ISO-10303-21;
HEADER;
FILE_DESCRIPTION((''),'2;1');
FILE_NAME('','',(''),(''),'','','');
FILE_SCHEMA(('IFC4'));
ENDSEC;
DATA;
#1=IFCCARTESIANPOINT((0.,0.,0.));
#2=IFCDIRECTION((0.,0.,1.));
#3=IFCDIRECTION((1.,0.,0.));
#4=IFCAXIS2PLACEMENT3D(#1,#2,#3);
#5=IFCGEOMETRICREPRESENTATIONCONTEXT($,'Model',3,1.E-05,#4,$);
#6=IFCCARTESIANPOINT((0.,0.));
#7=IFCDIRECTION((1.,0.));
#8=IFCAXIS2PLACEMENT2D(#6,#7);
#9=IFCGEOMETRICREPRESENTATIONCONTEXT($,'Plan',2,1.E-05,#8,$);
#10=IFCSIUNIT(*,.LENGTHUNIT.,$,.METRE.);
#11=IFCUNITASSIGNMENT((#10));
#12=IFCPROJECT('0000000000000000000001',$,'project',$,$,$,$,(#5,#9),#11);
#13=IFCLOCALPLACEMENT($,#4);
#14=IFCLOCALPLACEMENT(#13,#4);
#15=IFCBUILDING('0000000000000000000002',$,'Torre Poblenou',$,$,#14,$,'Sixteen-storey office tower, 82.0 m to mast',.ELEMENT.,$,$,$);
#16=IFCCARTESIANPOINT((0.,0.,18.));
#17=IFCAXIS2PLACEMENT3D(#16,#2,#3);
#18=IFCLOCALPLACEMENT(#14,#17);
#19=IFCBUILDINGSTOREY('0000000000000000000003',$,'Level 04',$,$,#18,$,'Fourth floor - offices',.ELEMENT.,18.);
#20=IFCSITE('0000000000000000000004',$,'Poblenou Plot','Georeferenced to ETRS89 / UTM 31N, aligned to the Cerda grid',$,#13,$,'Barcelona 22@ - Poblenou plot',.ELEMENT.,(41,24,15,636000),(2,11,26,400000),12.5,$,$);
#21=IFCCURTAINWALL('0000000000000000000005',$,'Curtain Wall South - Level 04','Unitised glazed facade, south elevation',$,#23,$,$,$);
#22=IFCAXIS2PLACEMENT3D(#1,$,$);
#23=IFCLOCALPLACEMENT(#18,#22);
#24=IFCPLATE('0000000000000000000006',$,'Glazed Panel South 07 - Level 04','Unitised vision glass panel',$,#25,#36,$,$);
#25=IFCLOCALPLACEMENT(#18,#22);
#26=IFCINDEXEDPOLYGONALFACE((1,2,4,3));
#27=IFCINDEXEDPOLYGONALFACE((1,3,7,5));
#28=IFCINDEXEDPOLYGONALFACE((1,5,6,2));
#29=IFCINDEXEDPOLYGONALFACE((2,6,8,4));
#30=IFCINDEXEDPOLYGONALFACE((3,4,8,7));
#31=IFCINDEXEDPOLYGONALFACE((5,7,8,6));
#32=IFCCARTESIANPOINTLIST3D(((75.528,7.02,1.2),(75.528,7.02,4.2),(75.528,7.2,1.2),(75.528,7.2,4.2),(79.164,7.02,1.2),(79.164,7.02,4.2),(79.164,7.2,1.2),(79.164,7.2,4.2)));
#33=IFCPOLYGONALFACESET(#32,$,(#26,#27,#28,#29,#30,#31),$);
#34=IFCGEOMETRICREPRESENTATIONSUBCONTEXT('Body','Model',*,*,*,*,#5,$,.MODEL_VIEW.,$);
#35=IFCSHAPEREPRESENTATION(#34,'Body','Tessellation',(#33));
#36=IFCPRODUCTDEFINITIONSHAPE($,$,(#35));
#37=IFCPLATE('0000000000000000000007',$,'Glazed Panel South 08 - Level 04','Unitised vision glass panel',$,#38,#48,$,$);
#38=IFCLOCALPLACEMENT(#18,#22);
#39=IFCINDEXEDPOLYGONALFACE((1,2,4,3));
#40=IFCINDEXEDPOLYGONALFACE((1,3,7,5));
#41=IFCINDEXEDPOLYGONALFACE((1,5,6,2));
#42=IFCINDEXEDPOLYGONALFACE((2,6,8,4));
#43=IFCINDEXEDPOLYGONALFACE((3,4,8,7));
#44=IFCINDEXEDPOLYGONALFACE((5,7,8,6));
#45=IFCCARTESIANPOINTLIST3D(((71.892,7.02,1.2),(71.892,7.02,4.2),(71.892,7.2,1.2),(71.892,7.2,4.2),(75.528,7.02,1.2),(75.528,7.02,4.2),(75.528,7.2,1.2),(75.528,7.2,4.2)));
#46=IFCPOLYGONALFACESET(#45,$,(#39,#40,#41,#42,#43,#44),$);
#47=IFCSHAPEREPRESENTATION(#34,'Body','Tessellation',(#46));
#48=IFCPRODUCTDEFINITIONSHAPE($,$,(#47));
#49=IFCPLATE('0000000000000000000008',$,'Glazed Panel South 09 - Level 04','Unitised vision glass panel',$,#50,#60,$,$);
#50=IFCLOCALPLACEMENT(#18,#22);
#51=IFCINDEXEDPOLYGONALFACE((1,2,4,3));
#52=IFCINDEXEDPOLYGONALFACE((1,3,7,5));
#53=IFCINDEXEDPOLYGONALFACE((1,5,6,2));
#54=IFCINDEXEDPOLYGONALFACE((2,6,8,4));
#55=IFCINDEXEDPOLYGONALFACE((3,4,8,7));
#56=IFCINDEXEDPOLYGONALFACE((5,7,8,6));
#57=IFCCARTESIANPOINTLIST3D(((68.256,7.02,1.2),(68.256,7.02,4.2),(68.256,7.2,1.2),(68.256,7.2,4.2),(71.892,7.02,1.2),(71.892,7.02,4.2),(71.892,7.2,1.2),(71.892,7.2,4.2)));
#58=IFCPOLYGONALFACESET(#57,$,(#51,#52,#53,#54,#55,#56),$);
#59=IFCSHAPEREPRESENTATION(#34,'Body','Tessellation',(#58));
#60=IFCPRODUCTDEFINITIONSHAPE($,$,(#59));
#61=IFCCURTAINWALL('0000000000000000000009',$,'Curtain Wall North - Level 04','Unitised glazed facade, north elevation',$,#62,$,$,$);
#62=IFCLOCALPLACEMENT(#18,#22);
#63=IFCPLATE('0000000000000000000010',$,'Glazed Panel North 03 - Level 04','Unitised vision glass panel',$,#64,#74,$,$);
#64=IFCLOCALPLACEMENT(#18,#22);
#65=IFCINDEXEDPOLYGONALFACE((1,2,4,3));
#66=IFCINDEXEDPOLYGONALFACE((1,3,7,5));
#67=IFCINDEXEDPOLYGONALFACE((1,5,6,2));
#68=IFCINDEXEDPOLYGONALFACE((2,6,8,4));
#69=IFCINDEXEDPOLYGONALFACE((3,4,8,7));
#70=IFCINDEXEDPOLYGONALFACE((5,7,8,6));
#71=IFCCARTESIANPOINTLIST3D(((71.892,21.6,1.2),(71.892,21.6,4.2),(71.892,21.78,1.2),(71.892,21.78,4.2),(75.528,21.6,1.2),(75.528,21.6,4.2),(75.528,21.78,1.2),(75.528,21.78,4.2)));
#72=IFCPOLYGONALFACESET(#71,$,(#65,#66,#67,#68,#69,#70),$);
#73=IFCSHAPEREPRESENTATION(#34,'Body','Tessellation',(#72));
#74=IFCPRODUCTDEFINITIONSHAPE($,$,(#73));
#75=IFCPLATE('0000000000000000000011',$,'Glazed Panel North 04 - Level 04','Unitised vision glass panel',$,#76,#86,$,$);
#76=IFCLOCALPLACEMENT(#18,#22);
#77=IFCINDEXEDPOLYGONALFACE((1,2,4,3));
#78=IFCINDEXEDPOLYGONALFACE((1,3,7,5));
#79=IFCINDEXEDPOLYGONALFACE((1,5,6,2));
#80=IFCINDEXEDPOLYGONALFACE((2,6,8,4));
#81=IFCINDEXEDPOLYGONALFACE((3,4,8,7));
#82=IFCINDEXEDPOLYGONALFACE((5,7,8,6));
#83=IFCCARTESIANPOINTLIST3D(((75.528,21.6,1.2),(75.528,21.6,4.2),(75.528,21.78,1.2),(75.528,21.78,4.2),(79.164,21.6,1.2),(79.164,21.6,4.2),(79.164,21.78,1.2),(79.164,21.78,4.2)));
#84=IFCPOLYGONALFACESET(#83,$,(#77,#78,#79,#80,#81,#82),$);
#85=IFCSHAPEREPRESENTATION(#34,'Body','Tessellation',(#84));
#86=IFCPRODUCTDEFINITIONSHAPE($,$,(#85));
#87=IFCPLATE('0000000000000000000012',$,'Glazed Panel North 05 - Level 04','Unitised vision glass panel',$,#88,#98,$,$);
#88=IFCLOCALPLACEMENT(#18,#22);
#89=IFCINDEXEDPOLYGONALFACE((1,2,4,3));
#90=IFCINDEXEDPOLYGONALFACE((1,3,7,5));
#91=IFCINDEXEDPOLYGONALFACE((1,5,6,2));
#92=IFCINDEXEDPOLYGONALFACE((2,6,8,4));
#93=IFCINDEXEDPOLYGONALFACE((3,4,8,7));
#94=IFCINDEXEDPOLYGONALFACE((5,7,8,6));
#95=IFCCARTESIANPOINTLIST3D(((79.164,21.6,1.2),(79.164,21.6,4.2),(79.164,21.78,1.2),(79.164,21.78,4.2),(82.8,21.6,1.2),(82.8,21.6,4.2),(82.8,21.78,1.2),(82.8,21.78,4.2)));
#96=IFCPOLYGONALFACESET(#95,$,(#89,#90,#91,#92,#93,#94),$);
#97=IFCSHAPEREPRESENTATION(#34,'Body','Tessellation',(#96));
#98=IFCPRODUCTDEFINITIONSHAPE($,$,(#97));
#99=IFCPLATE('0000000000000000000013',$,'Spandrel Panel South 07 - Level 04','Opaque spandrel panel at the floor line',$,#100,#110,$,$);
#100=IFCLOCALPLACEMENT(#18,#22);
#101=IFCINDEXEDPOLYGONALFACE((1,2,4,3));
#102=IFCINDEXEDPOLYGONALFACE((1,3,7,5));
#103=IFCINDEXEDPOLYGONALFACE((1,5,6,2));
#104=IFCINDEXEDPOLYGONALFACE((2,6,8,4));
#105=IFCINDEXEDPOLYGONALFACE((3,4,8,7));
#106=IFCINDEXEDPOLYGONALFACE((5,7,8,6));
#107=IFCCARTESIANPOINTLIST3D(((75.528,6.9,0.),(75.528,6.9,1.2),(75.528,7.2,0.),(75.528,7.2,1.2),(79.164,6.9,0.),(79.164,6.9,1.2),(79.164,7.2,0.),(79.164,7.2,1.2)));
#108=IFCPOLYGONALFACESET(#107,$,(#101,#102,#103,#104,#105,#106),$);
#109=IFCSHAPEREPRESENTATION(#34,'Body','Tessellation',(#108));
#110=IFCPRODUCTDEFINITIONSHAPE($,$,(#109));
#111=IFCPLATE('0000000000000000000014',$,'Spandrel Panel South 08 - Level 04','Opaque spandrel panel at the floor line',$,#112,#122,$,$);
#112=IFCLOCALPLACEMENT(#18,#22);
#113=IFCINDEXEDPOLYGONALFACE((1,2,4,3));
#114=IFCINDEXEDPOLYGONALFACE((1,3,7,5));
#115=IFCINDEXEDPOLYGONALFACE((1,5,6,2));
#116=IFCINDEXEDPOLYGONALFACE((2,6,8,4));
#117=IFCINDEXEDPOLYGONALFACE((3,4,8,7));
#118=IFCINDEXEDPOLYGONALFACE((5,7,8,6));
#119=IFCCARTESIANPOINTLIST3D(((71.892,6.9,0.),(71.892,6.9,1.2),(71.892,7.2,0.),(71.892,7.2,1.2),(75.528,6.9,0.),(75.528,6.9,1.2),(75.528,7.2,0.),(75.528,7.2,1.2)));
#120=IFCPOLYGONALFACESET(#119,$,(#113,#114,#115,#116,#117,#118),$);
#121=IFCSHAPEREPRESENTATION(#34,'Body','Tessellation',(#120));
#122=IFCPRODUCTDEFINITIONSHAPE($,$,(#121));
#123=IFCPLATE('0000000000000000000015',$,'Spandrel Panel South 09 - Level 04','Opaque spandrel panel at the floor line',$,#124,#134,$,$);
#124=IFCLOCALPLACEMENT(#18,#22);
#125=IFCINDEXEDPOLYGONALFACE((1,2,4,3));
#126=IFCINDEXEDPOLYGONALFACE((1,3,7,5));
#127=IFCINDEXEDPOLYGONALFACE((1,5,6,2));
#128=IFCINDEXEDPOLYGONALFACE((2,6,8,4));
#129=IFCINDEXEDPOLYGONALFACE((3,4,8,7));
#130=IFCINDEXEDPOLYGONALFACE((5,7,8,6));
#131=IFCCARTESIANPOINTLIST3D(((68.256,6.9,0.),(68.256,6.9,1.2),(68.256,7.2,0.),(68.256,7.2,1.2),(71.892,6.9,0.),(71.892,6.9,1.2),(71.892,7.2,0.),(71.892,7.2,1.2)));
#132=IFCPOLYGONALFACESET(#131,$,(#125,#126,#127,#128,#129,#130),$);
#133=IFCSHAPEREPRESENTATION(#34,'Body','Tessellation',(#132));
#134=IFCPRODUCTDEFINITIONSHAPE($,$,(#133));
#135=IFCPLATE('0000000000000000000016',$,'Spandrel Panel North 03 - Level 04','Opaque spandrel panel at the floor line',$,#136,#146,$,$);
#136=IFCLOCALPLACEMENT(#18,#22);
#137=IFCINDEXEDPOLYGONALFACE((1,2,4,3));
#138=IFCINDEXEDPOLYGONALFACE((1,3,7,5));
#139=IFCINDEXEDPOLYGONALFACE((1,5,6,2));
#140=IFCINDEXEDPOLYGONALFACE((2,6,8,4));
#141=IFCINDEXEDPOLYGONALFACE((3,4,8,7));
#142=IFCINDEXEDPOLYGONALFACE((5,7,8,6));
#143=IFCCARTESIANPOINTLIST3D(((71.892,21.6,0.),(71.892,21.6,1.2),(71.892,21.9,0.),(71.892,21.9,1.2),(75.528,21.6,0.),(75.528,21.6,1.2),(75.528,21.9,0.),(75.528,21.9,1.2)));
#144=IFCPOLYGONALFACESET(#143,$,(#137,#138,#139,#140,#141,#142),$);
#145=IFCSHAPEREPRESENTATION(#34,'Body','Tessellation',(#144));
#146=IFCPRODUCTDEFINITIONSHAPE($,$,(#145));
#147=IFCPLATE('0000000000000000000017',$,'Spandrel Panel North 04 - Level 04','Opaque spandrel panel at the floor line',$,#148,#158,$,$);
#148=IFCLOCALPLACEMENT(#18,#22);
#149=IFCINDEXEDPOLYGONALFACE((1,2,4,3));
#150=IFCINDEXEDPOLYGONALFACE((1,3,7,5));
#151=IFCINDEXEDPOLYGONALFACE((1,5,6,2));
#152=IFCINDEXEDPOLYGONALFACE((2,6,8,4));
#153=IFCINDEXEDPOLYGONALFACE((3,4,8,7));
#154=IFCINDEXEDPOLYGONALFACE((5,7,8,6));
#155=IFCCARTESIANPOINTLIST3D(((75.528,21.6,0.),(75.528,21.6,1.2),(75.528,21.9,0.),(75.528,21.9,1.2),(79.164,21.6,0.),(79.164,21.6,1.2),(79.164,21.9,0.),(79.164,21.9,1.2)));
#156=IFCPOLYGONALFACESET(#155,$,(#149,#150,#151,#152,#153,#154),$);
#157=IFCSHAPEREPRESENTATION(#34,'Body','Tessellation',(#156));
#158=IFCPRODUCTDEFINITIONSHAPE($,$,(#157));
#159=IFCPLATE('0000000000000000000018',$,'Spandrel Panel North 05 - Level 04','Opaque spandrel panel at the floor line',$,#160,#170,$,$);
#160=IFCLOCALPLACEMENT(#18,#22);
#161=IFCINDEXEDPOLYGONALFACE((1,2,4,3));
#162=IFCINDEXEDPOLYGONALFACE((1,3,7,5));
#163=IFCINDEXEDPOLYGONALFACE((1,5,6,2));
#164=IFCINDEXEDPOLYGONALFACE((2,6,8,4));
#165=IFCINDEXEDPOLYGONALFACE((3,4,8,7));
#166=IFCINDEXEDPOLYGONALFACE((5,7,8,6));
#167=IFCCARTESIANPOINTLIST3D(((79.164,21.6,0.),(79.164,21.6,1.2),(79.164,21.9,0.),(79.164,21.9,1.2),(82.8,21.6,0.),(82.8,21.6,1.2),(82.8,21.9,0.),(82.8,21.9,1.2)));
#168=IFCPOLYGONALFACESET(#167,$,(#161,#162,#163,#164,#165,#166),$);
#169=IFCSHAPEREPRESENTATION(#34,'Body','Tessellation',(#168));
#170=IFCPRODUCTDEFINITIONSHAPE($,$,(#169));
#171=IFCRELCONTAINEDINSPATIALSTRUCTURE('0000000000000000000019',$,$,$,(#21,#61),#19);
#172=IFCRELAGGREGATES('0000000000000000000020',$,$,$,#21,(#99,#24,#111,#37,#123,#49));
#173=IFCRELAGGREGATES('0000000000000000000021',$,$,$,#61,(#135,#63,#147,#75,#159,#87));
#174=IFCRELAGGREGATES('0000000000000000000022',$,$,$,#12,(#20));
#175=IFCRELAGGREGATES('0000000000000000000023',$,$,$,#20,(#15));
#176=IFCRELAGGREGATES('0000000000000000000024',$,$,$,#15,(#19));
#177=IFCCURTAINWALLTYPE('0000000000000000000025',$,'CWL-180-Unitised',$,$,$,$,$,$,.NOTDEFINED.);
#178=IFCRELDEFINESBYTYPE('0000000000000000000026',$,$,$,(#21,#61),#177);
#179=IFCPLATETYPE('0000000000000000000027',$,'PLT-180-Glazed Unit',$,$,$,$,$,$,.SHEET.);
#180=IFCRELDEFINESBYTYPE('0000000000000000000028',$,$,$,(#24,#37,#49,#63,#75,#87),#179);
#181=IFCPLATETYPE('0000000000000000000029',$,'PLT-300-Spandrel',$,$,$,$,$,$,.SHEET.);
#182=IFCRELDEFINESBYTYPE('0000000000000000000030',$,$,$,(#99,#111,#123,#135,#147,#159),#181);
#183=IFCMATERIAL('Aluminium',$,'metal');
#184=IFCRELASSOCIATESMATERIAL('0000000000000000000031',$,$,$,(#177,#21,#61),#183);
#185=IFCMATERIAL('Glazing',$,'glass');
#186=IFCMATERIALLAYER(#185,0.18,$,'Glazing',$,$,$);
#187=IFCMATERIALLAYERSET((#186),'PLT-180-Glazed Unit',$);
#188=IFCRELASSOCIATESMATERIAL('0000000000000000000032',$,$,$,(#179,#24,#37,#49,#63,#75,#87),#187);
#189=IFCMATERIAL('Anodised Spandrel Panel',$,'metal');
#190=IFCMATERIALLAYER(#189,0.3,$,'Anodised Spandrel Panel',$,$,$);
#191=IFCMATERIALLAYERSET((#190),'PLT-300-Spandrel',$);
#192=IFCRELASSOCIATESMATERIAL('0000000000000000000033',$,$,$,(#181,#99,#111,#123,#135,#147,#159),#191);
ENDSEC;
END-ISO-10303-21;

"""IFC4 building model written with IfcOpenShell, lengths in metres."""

from ifc_helpers import new_model, si_unit, frame, origin_with_axes, origin_2d_with_axis, place, context, subcontext, project, spatial, line, indexed_curve, outline, extrude, material, layer, layer_set, layer_usage, type_object, element, aggregate, save


model = new_model("IFC4")

# Units and contexts
model_context = context("Model", 3, precision=1e-05, world=origin_with_axes())
plan_context = context("Plan", 2, precision=1e-05, world=origin_2d_with_axis())
body_context = subcontext(model_context, "Body", "Model", "MODEL_VIEW")
ifc_project = project(units=[si_unit("LENGTHUNIT", "METRE")], contexts=[model_context, plan_context])

# Site, building, storey
site_placement = place(None, origin_with_axes())
site = spatial("IfcSite", under=ifc_project, at=site_placement, Name="Poblenou Plot", Description="Georeferenced to ETRS89 / UTM 31N, aligned to the Cerda grid", LongName="Barcelona 22@ - Poblenou plot", CompositionType="ELEMENT", RefLatitude=(41, 24, 15, 636000), RefLongitude=(2, 11, 26, 400000), RefElevation=12.5)
building_placement = place(site_placement, origin_with_axes())
building = spatial("IfcBuilding", under=site, at=building_placement, Name="Torre Poblenou", LongName="Sixteen-storey office tower, 82.0 m to mast", CompositionType="ELEMENT")
storey_placement = place(building_placement, frame((0.0, 0.0, 18.0), z_axis=(0.0, 0.0, 1.0), x_axis=(1.0, 0.0, 0.0)))
storey = spatial("IfcBuildingStorey", under=building, at=storey_placement, Name="Level 04", LongName="Fourth floor - offices", CompositionType="ELEMENT", Elevation=18.0)

# Curtain walls, plates
ifc_material_1 = material(Name="Aluminium", Category="metal")
curtain_wall_type = type_object("IfcCurtainWallType", Name="CWL-180-Unitised", PredefinedType="NOTDEFINED", material=ifc_material_1)
curtain_wall_1_placement = place(storey_placement, frame((100.98, 7.2, 0.0), z_axis=(0.0, 0.0, 1.0), x_axis=(-1.0, 0.0, 0.0)))
curtain_wall_1 = element("IfcCurtainWall", 1, at=curtain_wall_1_placement, inside=storey, type_object=curtain_wall_type, material=ifc_material_1, Name="Curtain Wall South - Level 04", Description="Unitised glazed facade, south elevation")
ifc_material_2 = material(Name="Glazing", Category="glass")
ifc_layer_1 = layer(ifc_material_2, 0.18, Name="Glazing")
ifc_layer_set_1 = layer_set([ifc_layer_1], Name="PLT-180-Glazed Unit")
ifc_layer_usage_1 = layer_usage(ifc_layer_set_1, "AXIS2", "POSITIVE", 0.0)
plate_type_1 = type_object("IfcPlateType", Name="PLT-180-Glazed Unit", PredefinedType="SHEET", material=ifc_layer_set_1)
plate_1_placement = place(curtain_wall_1_placement, frame((21.816, 0.0, 1.2), z_axis=(0.0, 0.0, 1.0), x_axis=(1.0, 0.0, 0.0)))
plate_1 = element("IfcPlate", 2, at=plate_1_placement, type_object=plate_type_1, material=ifc_layer_usage_1, Name="Glazed Panel South 07 - Level 04", Description="Unitised vision glass panel", context=body_context, shape_type="SweptSolid", body=[
    extrude(outline(indexed_curve([(0.0, 0.0), (3.636, 0.0), (3.636, 0.18), (0.0, 0.18)], segments=[line(1, 2, 3, 4, 1)])), origin_with_axes(), (0.0, 0.0, 1.0), 3.0),
])
ifc_layer_usage_2 = layer_usage(ifc_layer_set_1, "AXIS2", "POSITIVE", 0.0)
plate_2_placement = place(curtain_wall_1_placement, frame((25.452, 0.0, 1.2), z_axis=(0.0, 0.0, 1.0), x_axis=(1.0, 0.0, 0.0)))
plate_2 = element("IfcPlate", 3, at=plate_2_placement, type_object=plate_type_1, material=ifc_layer_usage_2, Name="Glazed Panel South 08 - Level 04", Description="Unitised vision glass panel", context=body_context, shape_type="SweptSolid", body=[
    extrude(outline(indexed_curve([(0.0, 0.0), (3.636, 0.0), (3.636, 0.18), (0.0, 0.18)], segments=[line(1, 2, 3, 4, 1)])), origin_with_axes(), (0.0, 0.0, 1.0), 3.0),
])
ifc_layer_usage_3 = layer_usage(ifc_layer_set_1, "AXIS2", "POSITIVE", 0.0)
plate_3_placement = place(curtain_wall_1_placement, frame((29.088, 0.0, 1.2), z_axis=(0.0, 0.0, 1.0), x_axis=(1.0, 0.0, 0.0)))
plate_3 = element("IfcPlate", 4, at=plate_3_placement, type_object=plate_type_1, material=ifc_layer_usage_3, Name="Glazed Panel South 09 - Level 04", Description="Unitised vision glass panel", context=body_context, shape_type="SweptSolid", body=[
    extrude(outline(indexed_curve([(0.0, 0.0), (3.636, 0.0), (3.636, 0.18), (0.0, 0.18)], segments=[line(1, 2, 3, 4, 1)])), origin_with_axes(), (0.0, 0.0, 1.0), 3.0),
])
curtain_wall_2_placement = place(storey_placement, frame((64.62, 21.6, 0.0), z_axis=(0.0, 0.0, 1.0), x_axis=(1.0, 0.0, 0.0)))
curtain_wall_2 = element("IfcCurtainWall", 5, at=curtain_wall_2_placement, inside=storey, type_object=curtain_wall_type, material=ifc_material_1, Name="Curtain Wall North - Level 04", Description="Unitised glazed facade, north elevation")
ifc_layer_usage_4 = layer_usage(ifc_layer_set_1, "AXIS2", "POSITIVE", 0.0)
plate_4_placement = place(curtain_wall_2_placement, frame((7.272, 0.0, 1.2), z_axis=(0.0, 0.0, 1.0), x_axis=(1.0, 0.0, 0.0)))
plate_4 = element("IfcPlate", 6, at=plate_4_placement, type_object=plate_type_1, material=ifc_layer_usage_4, Name="Glazed Panel North 03 - Level 04", Description="Unitised vision glass panel", context=body_context, shape_type="SweptSolid", body=[
    extrude(outline(indexed_curve([(0.0, 0.0), (3.636, 0.0), (3.636, 0.18), (0.0, 0.18)], segments=[line(1, 2, 3, 4, 1)])), origin_with_axes(), (0.0, 0.0, 1.0), 3.0),
])
ifc_layer_usage_5 = layer_usage(ifc_layer_set_1, "AXIS2", "POSITIVE", 0.0)
plate_5_placement = place(curtain_wall_2_placement, frame((10.908, 0.0, 1.2), z_axis=(0.0, 0.0, 1.0), x_axis=(1.0, 0.0, 0.0)))
plate_5 = element("IfcPlate", 7, at=plate_5_placement, type_object=plate_type_1, material=ifc_layer_usage_5, Name="Glazed Panel North 04 - Level 04", Description="Unitised vision glass panel", context=body_context, shape_type="SweptSolid", body=[
    extrude(outline(indexed_curve([(0.0, 0.0), (3.636, 0.0), (3.636, 0.18), (0.0, 0.18)], segments=[line(1, 2, 3, 4, 1)])), origin_with_axes(), (0.0, 0.0, 1.0), 3.0),
])
ifc_layer_usage_6 = layer_usage(ifc_layer_set_1, "AXIS2", "POSITIVE", 0.0)
plate_6_placement = place(curtain_wall_2_placement, frame((14.544, 0.0, 1.2), z_axis=(0.0, 0.0, 1.0), x_axis=(1.0, 0.0, 0.0)))
plate_6 = element("IfcPlate", 8, at=plate_6_placement, type_object=plate_type_1, material=ifc_layer_usage_6, Name="Glazed Panel North 05 - Level 04", Description="Unitised vision glass panel", context=body_context, shape_type="SweptSolid", body=[
    extrude(outline(indexed_curve([(0.0, 0.0), (3.636, 0.0), (3.636, 0.18), (0.0, 0.18)], segments=[line(1, 2, 3, 4, 1)])), origin_with_axes(), (0.0, 0.0, 1.0), 3.0),
])

# Plates
ifc_material_3 = material(Name="Anodised Spandrel Panel", Category="metal")
ifc_layer_2 = layer(ifc_material_3, 0.3, Name="Anodised Spandrel Panel")
ifc_layer_set_2 = layer_set([ifc_layer_2], Name="PLT-300-Spandrel")
ifc_layer_usage_7 = layer_usage(ifc_layer_set_2, "AXIS2", "POSITIVE", 0.0)
plate_type_2 = type_object("IfcPlateType", Name="PLT-300-Spandrel", PredefinedType="SHEET", material=ifc_layer_set_2)
plate_7_placement = place(curtain_wall_1_placement, frame((21.816, 0.0, 0.0), z_axis=(0.0, 0.0, 1.0), x_axis=(1.0, 0.0, 0.0)))
plate_7 = element("IfcPlate", 9, at=plate_7_placement, type_object=plate_type_2, material=ifc_layer_usage_7, Name="Spandrel Panel South 07 - Level 04", Description="Opaque spandrel panel at the floor line", context=body_context, shape_type="SweptSolid", body=[
    extrude(outline(indexed_curve([(0.0, 0.0), (3.636, 0.0), (3.636, 0.3), (0.0, 0.3)], segments=[line(1, 2, 3, 4, 1)])), origin_with_axes(), (0.0, 0.0, 1.0), 1.2),
])
ifc_layer_usage_8 = layer_usage(ifc_layer_set_2, "AXIS2", "POSITIVE", 0.0)
plate_8_placement = place(curtain_wall_1_placement, frame((25.452, 0.0, 0.0), z_axis=(0.0, 0.0, 1.0), x_axis=(1.0, 0.0, 0.0)))
plate_8 = element("IfcPlate", 10, at=plate_8_placement, type_object=plate_type_2, material=ifc_layer_usage_8, Name="Spandrel Panel South 08 - Level 04", Description="Opaque spandrel panel at the floor line", context=body_context, shape_type="SweptSolid", body=[
    extrude(outline(indexed_curve([(0.0, 0.0), (3.636, 0.0), (3.636, 0.3), (0.0, 0.3)], segments=[line(1, 2, 3, 4, 1)])), origin_with_axes(), (0.0, 0.0, 1.0), 1.2),
])
ifc_layer_usage_9 = layer_usage(ifc_layer_set_2, "AXIS2", "POSITIVE", 0.0)
plate_9_placement = place(curtain_wall_1_placement, frame((29.088, 0.0, 0.0), z_axis=(0.0, 0.0, 1.0), x_axis=(1.0, 0.0, 0.0)))
plate_9 = element("IfcPlate", 11, at=plate_9_placement, type_object=plate_type_2, material=ifc_layer_usage_9, Name="Spandrel Panel South 09 - Level 04", Description="Opaque spandrel panel at the floor line", context=body_context, shape_type="SweptSolid", body=[
    extrude(outline(indexed_curve([(0.0, 0.0), (3.636, 0.0), (3.636, 0.3), (0.0, 0.3)], segments=[line(1, 2, 3, 4, 1)])), origin_with_axes(), (0.0, 0.0, 1.0), 1.2),
])
aggregate(curtain_wall_1, [plate_7, plate_1, plate_8, plate_2, plate_9, plate_3])
ifc_layer_usage_10 = layer_usage(ifc_layer_set_2, "AXIS2", "POSITIVE", 0.0)
plate_10_placement = place(curtain_wall_2_placement, frame((7.272, 0.0, 0.0), z_axis=(0.0, 0.0, 1.0), x_axis=(1.0, 0.0, 0.0)))
plate_10 = element("IfcPlate", 12, at=plate_10_placement, type_object=plate_type_2, material=ifc_layer_usage_10, Name="Spandrel Panel North 03 - Level 04", Description="Opaque spandrel panel at the floor line", context=body_context, shape_type="SweptSolid", body=[
    extrude(outline(indexed_curve([(0.0, 0.0), (3.636, 0.0), (3.636, 0.3), (0.0, 0.3)], segments=[line(1, 2, 3, 4, 1)])), origin_with_axes(), (0.0, 0.0, 1.0), 1.2),
])
ifc_layer_usage_11 = layer_usage(ifc_layer_set_2, "AXIS2", "POSITIVE", 0.0)
plate_11_placement = place(curtain_wall_2_placement, frame((10.908, 0.0, 0.0), z_axis=(0.0, 0.0, 1.0), x_axis=(1.0, 0.0, 0.0)))
plate_11 = element("IfcPlate", 13, at=plate_11_placement, type_object=plate_type_2, material=ifc_layer_usage_11, Name="Spandrel Panel North 04 - Level 04", Description="Opaque spandrel panel at the floor line", context=body_context, shape_type="SweptSolid", body=[
    extrude(outline(indexed_curve([(0.0, 0.0), (3.636, 0.0), (3.636, 0.3), (0.0, 0.3)], segments=[line(1, 2, 3, 4, 1)])), origin_with_axes(), (0.0, 0.0, 1.0), 1.2),
])
ifc_layer_usage_12 = layer_usage(ifc_layer_set_2, "AXIS2", "POSITIVE", 0.0)
plate_12_placement = place(curtain_wall_2_placement, frame((14.544, 0.0, 0.0), z_axis=(0.0, 0.0, 1.0), x_axis=(1.0, 0.0, 0.0)))
plate_12 = element("IfcPlate", 14, at=plate_12_placement, type_object=plate_type_2, material=ifc_layer_usage_12, Name="Spandrel Panel North 05 - Level 04", Description="Opaque spandrel panel at the floor line", context=body_context, shape_type="SweptSolid", body=[
    extrude(outline(indexed_curve([(0.0, 0.0), (3.636, 0.0), (3.636, 0.3), (0.0, 0.3)], segments=[line(1, 2, 3, 4, 1)])), origin_with_axes(), (0.0, 0.0, 1.0), 1.2),
])
aggregate(curtain_wall_2, [plate_10, plate_4, plate_11, plate_5, plate_12, plate_6])

save(model, "model.ifc")
